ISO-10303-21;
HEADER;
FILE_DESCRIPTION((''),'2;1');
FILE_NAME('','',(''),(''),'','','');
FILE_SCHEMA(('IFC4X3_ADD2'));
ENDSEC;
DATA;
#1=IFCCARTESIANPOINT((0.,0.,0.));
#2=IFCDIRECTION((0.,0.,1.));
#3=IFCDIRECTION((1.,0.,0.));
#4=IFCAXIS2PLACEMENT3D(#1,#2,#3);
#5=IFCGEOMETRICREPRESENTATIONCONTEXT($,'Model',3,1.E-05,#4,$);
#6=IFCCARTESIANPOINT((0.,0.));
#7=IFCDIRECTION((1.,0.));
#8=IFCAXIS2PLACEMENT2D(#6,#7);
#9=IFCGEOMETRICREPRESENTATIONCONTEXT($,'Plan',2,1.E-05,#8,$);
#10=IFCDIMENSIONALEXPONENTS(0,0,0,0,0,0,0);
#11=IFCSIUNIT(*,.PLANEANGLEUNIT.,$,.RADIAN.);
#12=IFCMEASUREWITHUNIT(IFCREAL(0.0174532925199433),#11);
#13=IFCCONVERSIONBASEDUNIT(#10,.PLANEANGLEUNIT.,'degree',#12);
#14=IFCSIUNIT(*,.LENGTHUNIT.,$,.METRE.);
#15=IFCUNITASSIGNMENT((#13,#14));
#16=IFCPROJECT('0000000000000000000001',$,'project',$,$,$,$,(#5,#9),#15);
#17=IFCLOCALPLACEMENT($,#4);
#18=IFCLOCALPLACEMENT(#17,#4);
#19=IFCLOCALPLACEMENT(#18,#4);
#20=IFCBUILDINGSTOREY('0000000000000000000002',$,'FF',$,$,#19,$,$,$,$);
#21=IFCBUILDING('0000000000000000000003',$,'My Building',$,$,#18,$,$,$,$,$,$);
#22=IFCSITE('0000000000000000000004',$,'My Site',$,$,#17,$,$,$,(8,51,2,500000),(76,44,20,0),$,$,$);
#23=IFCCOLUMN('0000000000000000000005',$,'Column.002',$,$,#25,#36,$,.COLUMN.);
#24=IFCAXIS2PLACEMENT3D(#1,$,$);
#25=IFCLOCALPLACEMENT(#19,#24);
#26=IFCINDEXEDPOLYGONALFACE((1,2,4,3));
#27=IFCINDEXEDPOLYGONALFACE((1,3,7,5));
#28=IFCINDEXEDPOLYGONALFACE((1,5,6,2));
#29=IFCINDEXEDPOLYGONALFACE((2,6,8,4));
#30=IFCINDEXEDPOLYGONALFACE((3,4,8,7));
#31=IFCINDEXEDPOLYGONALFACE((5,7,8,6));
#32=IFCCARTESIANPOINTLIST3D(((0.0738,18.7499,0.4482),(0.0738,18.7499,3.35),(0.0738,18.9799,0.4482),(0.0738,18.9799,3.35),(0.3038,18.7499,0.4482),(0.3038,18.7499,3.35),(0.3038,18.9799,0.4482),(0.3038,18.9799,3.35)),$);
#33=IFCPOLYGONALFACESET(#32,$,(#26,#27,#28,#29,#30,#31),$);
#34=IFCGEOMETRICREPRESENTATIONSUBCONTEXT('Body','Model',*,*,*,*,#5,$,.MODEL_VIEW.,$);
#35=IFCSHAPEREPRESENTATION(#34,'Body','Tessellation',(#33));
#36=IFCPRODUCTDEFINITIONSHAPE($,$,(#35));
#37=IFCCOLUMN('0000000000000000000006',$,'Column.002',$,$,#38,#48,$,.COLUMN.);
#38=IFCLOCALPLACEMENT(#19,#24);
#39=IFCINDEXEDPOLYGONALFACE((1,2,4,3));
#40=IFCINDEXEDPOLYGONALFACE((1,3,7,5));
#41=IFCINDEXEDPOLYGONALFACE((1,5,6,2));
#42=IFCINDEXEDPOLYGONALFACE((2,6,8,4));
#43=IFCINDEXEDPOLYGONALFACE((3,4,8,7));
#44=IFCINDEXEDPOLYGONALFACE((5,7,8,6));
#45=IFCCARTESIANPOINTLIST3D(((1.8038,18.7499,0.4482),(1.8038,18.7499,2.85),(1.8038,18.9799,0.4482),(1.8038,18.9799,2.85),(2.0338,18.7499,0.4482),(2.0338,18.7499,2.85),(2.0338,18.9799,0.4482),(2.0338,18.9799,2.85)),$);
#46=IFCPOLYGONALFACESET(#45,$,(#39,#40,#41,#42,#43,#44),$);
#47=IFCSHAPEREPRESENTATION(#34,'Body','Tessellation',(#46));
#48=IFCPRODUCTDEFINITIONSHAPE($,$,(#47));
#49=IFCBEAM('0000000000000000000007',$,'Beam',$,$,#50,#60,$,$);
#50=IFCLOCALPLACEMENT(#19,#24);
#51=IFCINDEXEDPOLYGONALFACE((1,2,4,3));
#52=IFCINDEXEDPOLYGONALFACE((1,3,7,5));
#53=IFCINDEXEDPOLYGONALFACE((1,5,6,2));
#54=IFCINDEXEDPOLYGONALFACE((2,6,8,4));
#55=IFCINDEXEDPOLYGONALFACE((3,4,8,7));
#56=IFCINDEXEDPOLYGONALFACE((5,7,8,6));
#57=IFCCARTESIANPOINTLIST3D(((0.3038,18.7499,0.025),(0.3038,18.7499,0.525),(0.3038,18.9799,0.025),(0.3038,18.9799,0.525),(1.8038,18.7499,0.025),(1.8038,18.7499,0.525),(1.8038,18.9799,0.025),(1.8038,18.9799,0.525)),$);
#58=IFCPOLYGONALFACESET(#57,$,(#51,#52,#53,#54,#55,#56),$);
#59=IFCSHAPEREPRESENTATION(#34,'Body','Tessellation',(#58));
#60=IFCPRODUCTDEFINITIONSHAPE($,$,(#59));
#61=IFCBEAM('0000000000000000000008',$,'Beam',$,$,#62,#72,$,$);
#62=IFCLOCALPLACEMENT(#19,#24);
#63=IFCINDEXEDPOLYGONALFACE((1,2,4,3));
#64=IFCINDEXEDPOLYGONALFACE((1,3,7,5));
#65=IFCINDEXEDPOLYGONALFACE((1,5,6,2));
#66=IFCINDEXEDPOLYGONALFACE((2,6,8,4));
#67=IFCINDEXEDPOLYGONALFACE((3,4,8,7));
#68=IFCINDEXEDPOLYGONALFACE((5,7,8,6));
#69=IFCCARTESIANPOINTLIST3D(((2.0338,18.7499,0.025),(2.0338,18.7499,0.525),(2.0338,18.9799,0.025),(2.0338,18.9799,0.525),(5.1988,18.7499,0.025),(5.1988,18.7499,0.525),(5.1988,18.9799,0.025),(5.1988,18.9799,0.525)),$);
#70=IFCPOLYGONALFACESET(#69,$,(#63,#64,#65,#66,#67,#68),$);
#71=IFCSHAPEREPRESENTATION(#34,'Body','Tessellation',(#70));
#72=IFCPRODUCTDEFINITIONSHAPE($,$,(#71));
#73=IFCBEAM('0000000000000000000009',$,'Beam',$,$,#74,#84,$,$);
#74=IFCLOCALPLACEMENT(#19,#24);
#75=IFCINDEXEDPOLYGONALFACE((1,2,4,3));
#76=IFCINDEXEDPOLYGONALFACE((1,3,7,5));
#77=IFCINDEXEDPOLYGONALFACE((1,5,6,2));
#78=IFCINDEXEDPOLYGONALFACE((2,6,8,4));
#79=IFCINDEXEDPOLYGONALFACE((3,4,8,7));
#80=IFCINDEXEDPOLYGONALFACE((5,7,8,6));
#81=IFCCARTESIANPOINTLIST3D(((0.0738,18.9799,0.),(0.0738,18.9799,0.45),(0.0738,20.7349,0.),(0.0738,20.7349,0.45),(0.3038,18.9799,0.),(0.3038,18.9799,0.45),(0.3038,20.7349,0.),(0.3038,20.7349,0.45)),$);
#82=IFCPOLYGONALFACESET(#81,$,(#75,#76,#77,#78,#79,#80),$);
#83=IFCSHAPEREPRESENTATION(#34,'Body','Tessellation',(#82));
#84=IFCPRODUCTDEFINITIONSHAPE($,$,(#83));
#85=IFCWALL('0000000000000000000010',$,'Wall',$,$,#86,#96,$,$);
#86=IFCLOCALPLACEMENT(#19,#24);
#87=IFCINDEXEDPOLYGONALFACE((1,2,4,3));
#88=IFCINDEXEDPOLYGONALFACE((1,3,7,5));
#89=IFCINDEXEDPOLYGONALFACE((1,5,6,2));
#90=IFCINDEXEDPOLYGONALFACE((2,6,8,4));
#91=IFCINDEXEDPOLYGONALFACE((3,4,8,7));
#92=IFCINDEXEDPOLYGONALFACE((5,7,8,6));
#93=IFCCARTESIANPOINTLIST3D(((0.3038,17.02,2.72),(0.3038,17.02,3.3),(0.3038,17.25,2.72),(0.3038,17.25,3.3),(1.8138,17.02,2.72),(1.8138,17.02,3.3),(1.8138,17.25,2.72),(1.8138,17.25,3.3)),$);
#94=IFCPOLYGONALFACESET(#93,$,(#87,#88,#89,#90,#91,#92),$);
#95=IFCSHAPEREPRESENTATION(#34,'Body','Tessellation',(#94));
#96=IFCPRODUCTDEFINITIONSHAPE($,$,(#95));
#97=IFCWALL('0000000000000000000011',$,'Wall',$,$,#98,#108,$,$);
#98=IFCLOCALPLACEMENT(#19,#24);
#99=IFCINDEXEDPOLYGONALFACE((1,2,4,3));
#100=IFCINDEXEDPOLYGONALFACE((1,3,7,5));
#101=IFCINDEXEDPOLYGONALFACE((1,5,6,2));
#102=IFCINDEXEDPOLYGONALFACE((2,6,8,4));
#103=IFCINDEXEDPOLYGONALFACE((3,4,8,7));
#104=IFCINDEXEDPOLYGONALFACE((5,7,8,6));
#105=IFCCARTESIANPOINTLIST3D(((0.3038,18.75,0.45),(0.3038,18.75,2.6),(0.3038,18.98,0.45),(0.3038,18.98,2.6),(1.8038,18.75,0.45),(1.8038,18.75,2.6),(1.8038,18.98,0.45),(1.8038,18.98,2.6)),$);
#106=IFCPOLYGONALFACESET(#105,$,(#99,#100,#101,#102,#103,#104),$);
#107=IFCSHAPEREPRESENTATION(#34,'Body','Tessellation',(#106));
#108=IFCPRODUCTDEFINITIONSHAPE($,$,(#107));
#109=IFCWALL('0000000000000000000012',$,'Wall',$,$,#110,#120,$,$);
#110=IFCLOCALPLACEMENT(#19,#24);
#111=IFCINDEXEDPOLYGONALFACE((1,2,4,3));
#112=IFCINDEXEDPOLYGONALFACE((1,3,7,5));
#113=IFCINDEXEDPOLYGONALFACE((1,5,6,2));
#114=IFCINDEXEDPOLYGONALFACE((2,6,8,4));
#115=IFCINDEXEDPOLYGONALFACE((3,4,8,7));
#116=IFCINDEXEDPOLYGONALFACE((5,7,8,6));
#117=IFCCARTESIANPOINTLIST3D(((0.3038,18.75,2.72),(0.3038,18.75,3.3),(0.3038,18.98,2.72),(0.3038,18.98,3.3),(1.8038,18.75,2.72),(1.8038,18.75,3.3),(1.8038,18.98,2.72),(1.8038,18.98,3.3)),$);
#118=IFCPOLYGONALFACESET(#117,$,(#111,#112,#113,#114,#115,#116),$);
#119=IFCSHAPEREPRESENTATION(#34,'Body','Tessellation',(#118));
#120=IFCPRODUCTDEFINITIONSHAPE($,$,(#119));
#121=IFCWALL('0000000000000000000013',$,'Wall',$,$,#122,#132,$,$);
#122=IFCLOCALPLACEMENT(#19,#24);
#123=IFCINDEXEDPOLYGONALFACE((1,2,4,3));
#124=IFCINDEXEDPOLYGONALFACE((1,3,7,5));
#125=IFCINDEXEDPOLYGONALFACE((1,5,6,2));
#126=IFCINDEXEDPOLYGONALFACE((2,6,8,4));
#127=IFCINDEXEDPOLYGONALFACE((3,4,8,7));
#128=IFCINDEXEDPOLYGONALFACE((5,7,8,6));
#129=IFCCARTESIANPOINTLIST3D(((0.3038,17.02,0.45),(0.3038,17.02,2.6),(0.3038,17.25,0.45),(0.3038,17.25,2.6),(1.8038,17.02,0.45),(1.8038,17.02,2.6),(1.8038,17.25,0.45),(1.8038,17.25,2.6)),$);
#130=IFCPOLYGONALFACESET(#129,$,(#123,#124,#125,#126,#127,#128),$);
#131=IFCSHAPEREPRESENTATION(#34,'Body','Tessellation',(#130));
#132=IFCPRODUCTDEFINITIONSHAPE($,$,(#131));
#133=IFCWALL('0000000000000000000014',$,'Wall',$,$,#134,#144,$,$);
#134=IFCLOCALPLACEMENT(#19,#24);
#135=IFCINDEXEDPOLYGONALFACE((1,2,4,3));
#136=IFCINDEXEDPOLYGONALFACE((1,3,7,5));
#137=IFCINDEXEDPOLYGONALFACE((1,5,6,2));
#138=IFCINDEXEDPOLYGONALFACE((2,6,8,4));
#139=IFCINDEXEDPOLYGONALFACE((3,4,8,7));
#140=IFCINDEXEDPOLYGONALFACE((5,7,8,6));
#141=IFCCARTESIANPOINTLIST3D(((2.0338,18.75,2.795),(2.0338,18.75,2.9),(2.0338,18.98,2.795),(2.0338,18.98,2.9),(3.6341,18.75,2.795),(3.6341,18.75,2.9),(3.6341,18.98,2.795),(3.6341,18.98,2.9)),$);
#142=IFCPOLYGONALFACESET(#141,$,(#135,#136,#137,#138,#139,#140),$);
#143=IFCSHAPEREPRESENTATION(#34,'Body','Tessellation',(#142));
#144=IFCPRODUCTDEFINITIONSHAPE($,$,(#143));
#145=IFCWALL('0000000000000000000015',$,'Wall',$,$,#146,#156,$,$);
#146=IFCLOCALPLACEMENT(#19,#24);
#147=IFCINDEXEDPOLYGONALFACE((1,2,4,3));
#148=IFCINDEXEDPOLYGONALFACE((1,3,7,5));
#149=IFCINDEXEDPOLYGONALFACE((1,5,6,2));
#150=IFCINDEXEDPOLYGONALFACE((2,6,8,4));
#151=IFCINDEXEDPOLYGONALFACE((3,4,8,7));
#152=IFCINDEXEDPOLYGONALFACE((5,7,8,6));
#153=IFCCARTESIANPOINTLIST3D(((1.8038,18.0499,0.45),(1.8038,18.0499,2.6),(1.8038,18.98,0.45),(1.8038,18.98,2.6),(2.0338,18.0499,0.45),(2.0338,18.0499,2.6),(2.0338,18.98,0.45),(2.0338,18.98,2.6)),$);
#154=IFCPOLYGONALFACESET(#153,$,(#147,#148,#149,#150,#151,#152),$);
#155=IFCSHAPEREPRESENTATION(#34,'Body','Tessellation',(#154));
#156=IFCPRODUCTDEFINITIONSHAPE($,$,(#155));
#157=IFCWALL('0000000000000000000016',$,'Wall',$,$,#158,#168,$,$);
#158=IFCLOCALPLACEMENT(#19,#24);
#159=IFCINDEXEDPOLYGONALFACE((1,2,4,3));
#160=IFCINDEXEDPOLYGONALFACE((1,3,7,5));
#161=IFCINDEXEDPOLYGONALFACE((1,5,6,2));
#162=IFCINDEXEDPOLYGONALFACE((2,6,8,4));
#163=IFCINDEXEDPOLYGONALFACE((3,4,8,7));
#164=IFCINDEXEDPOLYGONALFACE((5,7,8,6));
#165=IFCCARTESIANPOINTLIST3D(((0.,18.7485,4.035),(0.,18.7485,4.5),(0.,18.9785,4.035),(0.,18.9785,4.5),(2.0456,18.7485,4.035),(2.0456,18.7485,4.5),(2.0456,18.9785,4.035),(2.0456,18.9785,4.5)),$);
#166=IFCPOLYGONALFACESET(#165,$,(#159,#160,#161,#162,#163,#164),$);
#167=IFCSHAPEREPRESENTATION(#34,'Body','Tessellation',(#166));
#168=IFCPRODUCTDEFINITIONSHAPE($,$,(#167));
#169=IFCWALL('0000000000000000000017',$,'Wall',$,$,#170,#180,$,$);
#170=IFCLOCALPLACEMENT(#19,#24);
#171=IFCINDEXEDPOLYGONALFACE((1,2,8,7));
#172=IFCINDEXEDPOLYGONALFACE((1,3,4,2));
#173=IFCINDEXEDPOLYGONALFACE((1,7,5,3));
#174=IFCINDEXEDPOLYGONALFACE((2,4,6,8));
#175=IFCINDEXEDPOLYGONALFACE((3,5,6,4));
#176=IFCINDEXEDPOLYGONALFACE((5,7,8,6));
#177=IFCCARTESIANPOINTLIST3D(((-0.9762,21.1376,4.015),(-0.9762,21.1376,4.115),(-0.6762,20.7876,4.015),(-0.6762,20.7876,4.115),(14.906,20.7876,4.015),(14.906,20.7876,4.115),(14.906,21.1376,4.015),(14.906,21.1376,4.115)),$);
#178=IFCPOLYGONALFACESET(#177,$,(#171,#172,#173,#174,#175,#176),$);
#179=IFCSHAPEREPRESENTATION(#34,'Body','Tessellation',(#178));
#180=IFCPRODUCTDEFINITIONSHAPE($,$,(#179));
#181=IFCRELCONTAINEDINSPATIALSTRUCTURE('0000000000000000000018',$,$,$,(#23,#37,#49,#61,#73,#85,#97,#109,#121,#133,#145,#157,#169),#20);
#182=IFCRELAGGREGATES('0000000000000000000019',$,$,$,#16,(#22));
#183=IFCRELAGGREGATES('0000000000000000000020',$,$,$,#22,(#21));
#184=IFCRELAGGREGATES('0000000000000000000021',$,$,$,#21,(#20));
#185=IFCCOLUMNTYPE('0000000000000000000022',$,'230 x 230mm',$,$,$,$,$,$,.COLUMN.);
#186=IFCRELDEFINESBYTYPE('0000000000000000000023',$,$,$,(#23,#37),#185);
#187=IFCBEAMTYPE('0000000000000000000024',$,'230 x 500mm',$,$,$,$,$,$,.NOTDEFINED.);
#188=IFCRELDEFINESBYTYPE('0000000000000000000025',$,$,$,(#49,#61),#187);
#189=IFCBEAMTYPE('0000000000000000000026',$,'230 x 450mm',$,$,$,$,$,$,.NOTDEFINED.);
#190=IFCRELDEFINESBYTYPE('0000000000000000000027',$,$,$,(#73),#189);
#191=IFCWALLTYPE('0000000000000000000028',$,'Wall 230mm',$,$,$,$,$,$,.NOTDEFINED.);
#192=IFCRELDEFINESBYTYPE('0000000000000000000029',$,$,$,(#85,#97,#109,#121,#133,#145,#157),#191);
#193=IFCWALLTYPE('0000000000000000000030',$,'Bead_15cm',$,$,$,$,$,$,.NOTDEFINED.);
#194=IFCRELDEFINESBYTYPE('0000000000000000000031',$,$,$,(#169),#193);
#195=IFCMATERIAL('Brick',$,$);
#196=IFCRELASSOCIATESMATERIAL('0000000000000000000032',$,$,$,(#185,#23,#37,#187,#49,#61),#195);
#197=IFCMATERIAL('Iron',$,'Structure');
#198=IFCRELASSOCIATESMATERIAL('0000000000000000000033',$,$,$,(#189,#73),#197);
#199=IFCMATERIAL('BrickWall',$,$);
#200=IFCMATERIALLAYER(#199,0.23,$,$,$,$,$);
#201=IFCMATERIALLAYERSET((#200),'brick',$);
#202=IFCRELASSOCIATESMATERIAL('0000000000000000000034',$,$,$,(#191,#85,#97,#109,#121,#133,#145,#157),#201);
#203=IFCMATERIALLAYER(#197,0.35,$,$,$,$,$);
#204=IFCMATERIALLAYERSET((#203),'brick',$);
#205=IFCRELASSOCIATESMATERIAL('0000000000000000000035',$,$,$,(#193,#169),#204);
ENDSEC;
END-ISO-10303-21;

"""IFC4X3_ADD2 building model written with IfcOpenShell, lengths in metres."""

from ifc_helpers import new_model, entity, si_unit, converted_unit, frame, origin_with_axes, origin_2d_with_axis, place, context, subcontext, project, spatial, line, indexed_curve, rectangle, outline, extrude, material, layer, layer_set, layer_usage, material_profile, profile_set, profile_usage, type_object, element, save


model = new_model("IFC4X3_ADD2")

# Units and contexts
model_context = context("Model", 3, precision=1e-05, world=origin_with_axes())
plan_context = context("Plan", 2, precision=1e-05, world=origin_2d_with_axis())
body_context = subcontext(model_context, "Body", "Model", "MODEL_VIEW")
ifc_project = project(units=[converted_unit("PLANEANGLEUNIT", "degree", entity("IfcReal", 0.0174532925199433), si_unit("PLANEANGLEUNIT", "RADIAN"), dimensions=[0, 0, 0, 0, 0, 0, 0]), si_unit("LENGTHUNIT", "METRE")], contexts=[model_context, plan_context])

# Site, building, storey
site_placement = place(None, origin_with_axes())
site = spatial("IfcSite", under=ifc_project, at=site_placement, Name="My Site", RefLatitude=(8, 51, 2, 500000), RefLongitude=(76, 44, 20, 0))
building_placement = place(site_placement, origin_with_axes())
building = spatial("IfcBuilding", under=site, at=building_placement, Name="My Building")
storey_placement = place(building_placement, origin_with_axes())
storey = spatial("IfcBuildingStorey", under=building, at=storey_placement, Name="FF")

# Columns
ifc_material_1 = material(Name="Brick")
ifc_material_profile_1 = material_profile(ifc_material_1, outline(indexed_curve([(-0.115, 0.115), (0.115, 0.115), (0.115, -0.115), (-0.115, -0.115), (-0.115, 0.115)])))
ifc_profile_set_1 = profile_set([ifc_material_profile_1])
ifc_profile_usage_1 = profile_usage(ifc_profile_set_1)
column_type = type_object("IfcColumnType", Name="230 x 230mm", PredefinedType="COLUMN", material=ifc_profile_set_1)
column_1_placement = place(storey_placement, frame((0.1888, 18.8649, 0.4482), z_axis=(0.0, 0.0, 1.0), x_axis=(1.0, 0.0, 0.0)))
element("IfcColumn", 1, at=column_1_placement, inside=storey, type_object=column_type, material=ifc_profile_usage_1, Name="Column.002", PredefinedType="COLUMN", context=body_context, shape_type="SweptSolid", body=[
    extrude(outline(indexed_curve([(-0.115, 0.115), (0.115, 0.115), (0.115, -0.115), (-0.115, -0.115), (-0.115, 0.115)])), origin_with_axes(), (0.0, 0.0, 1.0), 2.9018),
])
ifc_profile_usage_2 = profile_usage(ifc_profile_set_1)
column_2_placement = place(storey_placement, frame((1.9188, 18.8649, 0.4482), z_axis=(0.0, 0.0, 1.0), x_axis=(1.0, 0.0, 0.0)))
element("IfcColumn", 2, at=column_2_placement, inside=storey, type_object=column_type, material=ifc_profile_usage_2, Name="Column.002", PredefinedType="COLUMN", context=body_context, shape_type="SweptSolid", body=[
    extrude(outline(indexed_curve([(-0.115, 0.115), (0.115, 0.115), (0.115, -0.115), (-0.115, -0.115), (-0.115, 0.115)])), origin_with_axes(), (0.0, 0.0, 1.0), 2.4018),
])

# Beams
ifc_material_profile_2 = material_profile(ifc_material_1, rectangle(XDim=0.23, YDim=0.5))
ifc_profile_set_2 = profile_set([ifc_material_profile_2], Name="rcc")
ifc_profile_usage_3 = profile_usage(ifc_profile_set_2)
beam_type_1 = type_object("IfcBeamType", Name="230 x 500mm", PredefinedType="NOTDEFINED", material=ifc_profile_set_2)
beam_1_placement = place(storey_placement, frame((0.3038, 18.8649, 0.275), z_axis=(1.0, 0.0, 0.0), x_axis=(0.0, 1.0, 0.0)))
element("IfcBeam", 3, at=beam_1_placement, inside=storey, type_object=beam_type_1, material=ifc_profile_usage_3, Name="Beam", context=body_context, shape_type="SweptSolid", body=[
    extrude(rectangle(XDim=0.23, YDim=0.5), origin_with_axes(), (0.0, 0.0, 1.0), 1.5),
])
ifc_profile_usage_4 = profile_usage(ifc_profile_set_2)
beam_2_placement = place(storey_placement, frame((2.0338, 18.8649, 0.275), z_axis=(1.0, 0.0, 0.0), x_axis=(0.0, 1.0, 0.0)))
element("IfcBeam", 4, at=beam_2_placement, inside=storey, type_object=beam_type_1, material=ifc_profile_usage_4, Name="Beam", context=body_context, shape_type="SweptSolid", body=[
    extrude(rectangle(XDim=0.23, YDim=0.5), origin_with_axes(), (0.0, 0.0, 1.0), 3.165),
])
ifc_material_2 = material(Name="Iron", Category="Structure")
ifc_material_profile_3 = material_profile(ifc_material_2, rectangle(XDim=0.23, YDim=0.45))
ifc_profile_set_3 = profile_set([ifc_material_profile_3], Name="blank")
ifc_profile_usage_5 = profile_usage(ifc_profile_set_3)
beam_type_2 = type_object("IfcBeamType", Name="230 x 450mm", PredefinedType="NOTDEFINED", material=ifc_profile_set_3)
beam_3_placement = place(storey_placement, frame((0.1888, 18.9799, 0.225), z_axis=(0.0, 1.0, 0.0), x_axis=(-1.0, 0.0, 0.0)))
element("IfcBeam", 5, at=beam_3_placement, inside=storey, type_object=beam_type_2, material=ifc_profile_usage_5, Name="Beam", context=body_context, shape_type="SweptSolid", body=[
    extrude(rectangle(XDim=0.23, YDim=0.45), origin_with_axes(), (0.0, 0.0, 1.0), 1.755),
])

# Walls
ifc_material_3 = material(Name="BrickWall")
ifc_layer_1 = layer(ifc_material_3, 0.23)
ifc_layer_set_1 = layer_set([ifc_layer_1], Name="brick")
ifc_layer_usage_1 = layer_usage(ifc_layer_set_1, "AXIS2", "POSITIVE", 0.0)
wall_type_1 = type_object("IfcWallType", Name="Wall 230mm", PredefinedType="NOTDEFINED", material=ifc_layer_set_1)
wall_1_placement = place(storey_placement, frame((1.8138, 17.25, 2.72), z_axis=(0.0, 0.0, 1.0), x_axis=(-1.0, 0.0, 0.0)))
element("IfcWall", 6, at=wall_1_placement, inside=storey, type_object=wall_type_1, material=ifc_layer_usage_1, Name="Wall", context=body_context, shape_type="SweptSolid", body=[
    extrude(outline(indexed_curve([(0.0, 0.0), (0.0, 0.23), (1.51, 0.23), (1.51, 0.0)], segments=[line(1, 2, 3, 4, 1)])), origin_with_axes(), (0.0, 0.0, 1.0), 0.58),
])
ifc_layer_usage_2 = layer_usage(ifc_layer_set_1, "AXIS2", "POSITIVE", 0.0)
wall_2_placement = place(storey_placement, frame((1.8038, 18.98, 0.45), z_axis=(0.0, 0.0, 1.0), x_axis=(-1.0, 0.0, 0.0)))
element("IfcWall", 7, at=wall_2_placement, inside=storey, type_object=wall_type_1, material=ifc_layer_usage_2, Name="Wall", context=body_context, shape_type="SweptSolid", body=[
    extrude(outline(indexed_curve([(0.0, 0.0), (0.0, 0.23), (1.5, 0.23), (1.5, 0.0)], segments=[line(1, 2, 3, 4, 1)])), origin_with_axes(), (0.0, 0.0, 1.0), 2.15),
])
ifc_layer_usage_3 = layer_usage(ifc_layer_set_1, "AXIS2", "POSITIVE", 0.0)
wall_3_placement = place(storey_placement, frame((1.8038, 18.98, 2.72), z_axis=(0.0, 0.0, 1.0), x_axis=(-1.0, 0.0, 0.0)))
element("IfcWall", 8, at=wall_3_placement, inside=storey, type_object=wall_type_1, material=ifc_layer_usage_3, Name="Wall", context=body_context, shape_type="SweptSolid", body=[
    extrude(outline(indexed_curve([(0.0, 0.0), (0.0, 0.23), (1.5, 0.23), (1.5, 0.0)], segments=[line(1, 2, 3, 4, 1)])), origin_with_axes(), (0.0, 0.0, 1.0), 0.58),
])
ifc_layer_usage_4 = layer_usage(ifc_layer_set_1, "AXIS2", "POSITIVE", 0.0)
wall_4_placement = place(storey_placement, frame((1.8038, 17.25, 0.45), z_axis=(0.0, 0.0, 1.0), x_axis=(-1.0, 0.0, 0.0)))
element("IfcWall", 9, at=wall_4_placement, inside=storey, type_object=wall_type_1, material=ifc_layer_usage_4, Name="Wall", context=body_context, shape_type="SweptSolid", body=[
    extrude(outline(indexed_curve([(0.0, 0.0), (0.0, 0.23), (1.5, 0.23), (1.5, 0.0)], segments=[line(1, 2, 3, 4, 1)])), origin_with_axes(), (0.0, 0.0, 1.0), 2.15),
])

# Walls
ifc_layer_usage_5 = layer_usage(ifc_layer_set_1, "AXIS2", "POSITIVE", 0.0)
wall_5_placement = place(storey_placement, frame((3.6341, 18.98, 2.795), z_axis=(0.0, 0.0, 1.0), x_axis=(-1.0, 0.0, 0.0)))
element("IfcWall", 10, at=wall_5_placement, inside=storey, type_object=wall_type_1, material=ifc_layer_usage_5, Name="Wall", context=body_context, shape_type="SweptSolid", body=[
    extrude(outline(indexed_curve([(0.0, 0.0), (0.0, 0.23), (1.6002, 0.23), (1.6002, 0.0)], segments=[line(1, 2, 3, 4, 1)])), origin_with_axes(), (0.0, 0.0, 1.0), 0.105),
])
ifc_layer_usage_6 = layer_usage(ifc_layer_set_1, "AXIS2", "POSITIVE", 0.0)
wall_6_placement = place(storey_placement, frame((2.0338, 18.0499, 0.45), z_axis=(0.0, 0.0, 1.0), x_axis=(0.000001, 1.0, 0.0)))
element("IfcWall", 11, at=wall_6_placement, inside=storey, type_object=wall_type_1, material=ifc_layer_usage_6, Name="Wall", context=body_context, shape_type="SweptSolid", body=[
    extrude(outline(indexed_curve([(0.0, 0.0), (0.0, 0.23), (0.9301, 0.23), (0.9301, 0.0)], segments=[line(1, 2, 3, 4, 1)])), origin_with_axes(), (0.0, 0.0, 1.0), 2.15),
])
ifc_layer_usage_7 = layer_usage(ifc_layer_set_1, "AXIS2", "POSITIVE", 0.0)
wall_7_placement = place(storey_placement, frame((2.0456, 18.9785, 4.035), z_axis=(0.0, 0.0, 1.0), x_axis=(-1.0, 0.0, 0.0)))
element("IfcWall", 12, at=wall_7_placement, inside=storey, type_object=wall_type_1, material=ifc_layer_usage_7, Name="Wall", context=body_context, shape_type="SweptSolid", body=[
    extrude(outline(indexed_curve([(0.0, 0.0), (0.0, 0.23), (2.0455, 0.23), (2.0455, 0.0)], segments=[line(1, 2, 3, 4, 1)])), origin_with_axes(), (0.0, 0.0, 1.0), 0.465),
])
ifc_layer_2 = layer(ifc_material_2, 0.35)
ifc_layer_set_2 = layer_set([ifc_layer_2], Name="brick")
ifc_layer_usage_8 = layer_usage(ifc_layer_set_2, "AXIS2", "POSITIVE", 0.0)
wall_type_2 = type_object("IfcWallType", Name="Bead_15cm", PredefinedType="NOTDEFINED", material=ifc_layer_set_2)
wall_8_placement = place(storey_placement, frame((-0.6762, 20.7876, 4.015), z_axis=(0.0, 0.0, 1.0), x_axis=(1.0, -0.000001, 0.0)))
element("IfcWall", 13, at=wall_8_placement, inside=storey, type_object=wall_type_2, material=ifc_layer_usage_8, Name="Wall", context=body_context, shape_type="SweptSolid", body=[
    extrude(outline(indexed_curve([(0.0, 0.0), (-0.3, 0.35), (15.5822, 0.35), (15.5822, 0.0)], segments=[line(1, 2, 3, 4, 1)])), origin_with_axes(), (0.0, 0.0, 1.0), 0.1),
])

save(model, "model.ifc")
